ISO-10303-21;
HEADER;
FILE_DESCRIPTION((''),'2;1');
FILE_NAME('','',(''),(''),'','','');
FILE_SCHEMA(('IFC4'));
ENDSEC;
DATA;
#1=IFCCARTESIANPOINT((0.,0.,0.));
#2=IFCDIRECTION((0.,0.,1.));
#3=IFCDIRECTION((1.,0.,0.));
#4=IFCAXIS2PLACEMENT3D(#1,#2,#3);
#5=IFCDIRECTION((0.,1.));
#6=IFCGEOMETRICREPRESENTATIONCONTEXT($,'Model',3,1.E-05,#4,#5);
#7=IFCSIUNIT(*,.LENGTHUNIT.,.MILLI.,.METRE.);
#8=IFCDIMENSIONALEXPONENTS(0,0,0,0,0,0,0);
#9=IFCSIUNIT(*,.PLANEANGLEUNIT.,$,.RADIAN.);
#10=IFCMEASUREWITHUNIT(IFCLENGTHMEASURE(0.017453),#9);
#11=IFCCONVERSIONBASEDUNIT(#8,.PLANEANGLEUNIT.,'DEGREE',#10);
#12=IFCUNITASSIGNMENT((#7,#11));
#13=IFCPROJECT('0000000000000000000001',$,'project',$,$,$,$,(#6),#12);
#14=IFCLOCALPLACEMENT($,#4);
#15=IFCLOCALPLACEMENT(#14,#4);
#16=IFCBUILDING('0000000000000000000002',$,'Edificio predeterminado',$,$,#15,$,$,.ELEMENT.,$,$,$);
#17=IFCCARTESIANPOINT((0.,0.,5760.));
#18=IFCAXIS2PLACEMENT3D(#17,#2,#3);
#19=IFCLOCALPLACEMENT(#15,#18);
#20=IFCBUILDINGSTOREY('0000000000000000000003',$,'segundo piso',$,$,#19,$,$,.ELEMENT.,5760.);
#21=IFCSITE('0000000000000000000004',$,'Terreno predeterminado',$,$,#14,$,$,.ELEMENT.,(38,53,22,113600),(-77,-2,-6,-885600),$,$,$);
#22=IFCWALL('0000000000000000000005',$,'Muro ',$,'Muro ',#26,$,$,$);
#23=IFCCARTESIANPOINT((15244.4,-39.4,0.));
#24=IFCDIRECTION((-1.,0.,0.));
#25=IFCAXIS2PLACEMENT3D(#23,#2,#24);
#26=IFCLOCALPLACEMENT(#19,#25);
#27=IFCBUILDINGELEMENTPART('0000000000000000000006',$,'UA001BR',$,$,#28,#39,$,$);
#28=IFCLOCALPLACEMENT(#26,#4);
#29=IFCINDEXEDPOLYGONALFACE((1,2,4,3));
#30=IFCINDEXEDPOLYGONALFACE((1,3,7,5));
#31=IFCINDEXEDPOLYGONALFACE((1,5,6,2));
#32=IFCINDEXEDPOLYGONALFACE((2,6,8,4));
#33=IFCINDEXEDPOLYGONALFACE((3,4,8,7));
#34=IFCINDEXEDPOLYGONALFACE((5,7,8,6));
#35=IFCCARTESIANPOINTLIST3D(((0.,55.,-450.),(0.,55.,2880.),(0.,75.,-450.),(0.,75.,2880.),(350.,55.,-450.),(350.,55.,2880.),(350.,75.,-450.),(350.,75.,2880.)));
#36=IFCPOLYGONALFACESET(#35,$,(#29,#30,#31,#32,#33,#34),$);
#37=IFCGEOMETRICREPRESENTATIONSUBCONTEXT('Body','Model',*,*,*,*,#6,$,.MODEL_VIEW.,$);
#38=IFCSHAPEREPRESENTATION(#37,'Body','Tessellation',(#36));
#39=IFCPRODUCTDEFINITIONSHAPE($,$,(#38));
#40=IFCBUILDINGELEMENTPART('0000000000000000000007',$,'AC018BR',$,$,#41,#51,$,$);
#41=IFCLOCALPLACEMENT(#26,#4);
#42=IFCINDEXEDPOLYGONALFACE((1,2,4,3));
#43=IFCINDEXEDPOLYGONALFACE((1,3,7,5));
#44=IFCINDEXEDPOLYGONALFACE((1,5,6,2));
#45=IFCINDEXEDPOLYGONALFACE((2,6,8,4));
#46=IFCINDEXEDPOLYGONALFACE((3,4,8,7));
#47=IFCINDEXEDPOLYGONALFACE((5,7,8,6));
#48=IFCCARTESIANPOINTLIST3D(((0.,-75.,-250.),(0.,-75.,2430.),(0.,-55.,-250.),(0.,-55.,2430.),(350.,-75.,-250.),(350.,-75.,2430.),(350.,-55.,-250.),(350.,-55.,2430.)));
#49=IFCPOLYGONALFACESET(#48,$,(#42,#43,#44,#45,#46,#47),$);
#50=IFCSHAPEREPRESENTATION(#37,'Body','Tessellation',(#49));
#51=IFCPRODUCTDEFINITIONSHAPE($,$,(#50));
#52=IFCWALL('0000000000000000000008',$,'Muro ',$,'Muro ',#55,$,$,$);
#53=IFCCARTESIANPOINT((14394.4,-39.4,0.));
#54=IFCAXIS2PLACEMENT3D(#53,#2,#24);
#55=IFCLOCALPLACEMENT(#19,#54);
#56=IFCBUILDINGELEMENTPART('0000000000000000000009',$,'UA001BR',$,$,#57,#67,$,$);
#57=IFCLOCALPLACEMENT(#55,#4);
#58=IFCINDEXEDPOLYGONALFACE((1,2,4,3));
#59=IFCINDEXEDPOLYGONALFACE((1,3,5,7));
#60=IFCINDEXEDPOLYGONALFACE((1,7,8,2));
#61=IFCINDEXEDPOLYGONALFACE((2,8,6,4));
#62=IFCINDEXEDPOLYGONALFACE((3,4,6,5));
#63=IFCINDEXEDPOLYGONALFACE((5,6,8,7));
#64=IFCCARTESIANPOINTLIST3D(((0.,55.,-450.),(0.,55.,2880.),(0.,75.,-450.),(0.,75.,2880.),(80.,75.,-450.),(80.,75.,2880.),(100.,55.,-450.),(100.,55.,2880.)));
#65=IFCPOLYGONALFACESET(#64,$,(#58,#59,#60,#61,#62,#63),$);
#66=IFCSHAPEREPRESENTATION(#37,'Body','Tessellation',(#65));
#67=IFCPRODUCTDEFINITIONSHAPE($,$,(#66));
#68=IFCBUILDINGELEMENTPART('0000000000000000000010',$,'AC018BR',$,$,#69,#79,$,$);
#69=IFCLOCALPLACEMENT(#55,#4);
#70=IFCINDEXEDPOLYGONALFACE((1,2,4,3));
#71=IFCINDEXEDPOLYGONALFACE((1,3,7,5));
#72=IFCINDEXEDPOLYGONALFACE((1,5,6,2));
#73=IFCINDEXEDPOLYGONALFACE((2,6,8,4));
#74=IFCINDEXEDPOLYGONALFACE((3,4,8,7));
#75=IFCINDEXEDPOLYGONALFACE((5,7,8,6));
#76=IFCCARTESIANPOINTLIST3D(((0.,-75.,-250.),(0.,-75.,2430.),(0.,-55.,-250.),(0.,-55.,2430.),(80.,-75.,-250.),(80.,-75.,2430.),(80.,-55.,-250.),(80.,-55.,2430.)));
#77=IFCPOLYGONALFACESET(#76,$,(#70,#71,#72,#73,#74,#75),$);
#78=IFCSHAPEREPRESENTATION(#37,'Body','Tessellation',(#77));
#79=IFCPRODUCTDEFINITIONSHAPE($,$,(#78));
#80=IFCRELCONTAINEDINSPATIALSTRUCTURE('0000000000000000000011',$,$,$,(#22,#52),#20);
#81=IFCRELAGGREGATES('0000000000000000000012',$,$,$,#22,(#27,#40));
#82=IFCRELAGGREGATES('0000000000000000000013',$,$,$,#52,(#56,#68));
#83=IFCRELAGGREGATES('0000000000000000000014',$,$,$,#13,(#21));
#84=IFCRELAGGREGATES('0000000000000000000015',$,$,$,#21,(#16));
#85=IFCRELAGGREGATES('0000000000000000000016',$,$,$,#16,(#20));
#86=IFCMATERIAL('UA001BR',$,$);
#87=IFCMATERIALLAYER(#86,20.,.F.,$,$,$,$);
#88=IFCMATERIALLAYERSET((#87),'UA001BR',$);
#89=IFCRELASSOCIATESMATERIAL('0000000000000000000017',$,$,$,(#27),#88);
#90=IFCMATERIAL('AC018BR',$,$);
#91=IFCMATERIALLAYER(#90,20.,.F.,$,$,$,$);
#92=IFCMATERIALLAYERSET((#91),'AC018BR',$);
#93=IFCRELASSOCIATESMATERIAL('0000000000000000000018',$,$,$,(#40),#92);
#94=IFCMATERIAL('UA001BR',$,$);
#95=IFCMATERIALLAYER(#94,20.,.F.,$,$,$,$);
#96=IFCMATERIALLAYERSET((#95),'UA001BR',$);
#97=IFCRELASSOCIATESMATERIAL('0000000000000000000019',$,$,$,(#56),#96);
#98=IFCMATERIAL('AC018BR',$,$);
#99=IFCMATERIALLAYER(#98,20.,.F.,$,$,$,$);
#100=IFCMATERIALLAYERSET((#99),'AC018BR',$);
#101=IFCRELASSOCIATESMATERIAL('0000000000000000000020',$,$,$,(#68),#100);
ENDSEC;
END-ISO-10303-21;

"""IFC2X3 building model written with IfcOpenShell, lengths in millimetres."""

from ifc_helpers import new_model, entity, si_unit, converted_unit, direction, frame, origin_with_axes, place, context, subcontext, project, spatial, polyline, outline, extrude, material, layer, layer_set, layer_usage, element, aggregate, save


model = new_model("IFC2X3")

# Units and contexts
model_context = context("Model", 3, precision=1e-05, world=origin_with_axes(), true_north=direction((0.0, 1.0)))
body_context = subcontext(model_context, "Body", "Model", "MODEL_VIEW")
ifc_project = project(units=[si_unit("LENGTHUNIT", "METRE", prefix="MILLI"), converted_unit("PLANEANGLEUNIT", "DEGREE", entity("IfcLengthMeasure", 0.017453), si_unit("PLANEANGLEUNIT", "RADIAN"), dimensions=[0, 0, 0, 0, 0, 0, 0])], contexts=[model_context])

# Site, building, storey
site_placement = place(None, origin_with_axes())
site = spatial("IfcSite", under=ifc_project, at=site_placement, Name="Terreno predeterminado", CompositionType="ELEMENT", RefLatitude=(38, 53, 22, 113600), RefLongitude=(-77, -2, -6, -885600))
building_placement = place(site_placement, origin_with_axes())
building = spatial("IfcBuilding", under=site, at=building_placement, Name="Edificio predeterminado", CompositionType="ELEMENT")
storey_placement = place(building_placement, frame((0.0, 0.0, 5760.0), z_axis=(0.0, 0.0, 1.0), x_axis=(1.0, 0.0, 0.0)))
storey = spatial("IfcBuildingStorey", under=building, at=storey_placement, Name="segundo piso", CompositionType="ELEMENT", Elevation=5760.0)

# Walls, building element parts
wall_1_placement = place(storey_placement, frame((15244.4, -39.4, 0.0), z_axis=(0.0, 0.0, 1.0), x_axis=(-1.0, 0.0, 0.0)))
wall_1 = element("IfcWall", 1, at=wall_1_placement, inside=storey, Name="Muro ", ObjectType="Muro ")
ifc_material_1 = material(Name="UA001BR")
ifc_layer_1 = layer(ifc_material_1, 20.0, ventilated=False)
ifc_layer_set_1 = layer_set([ifc_layer_1], Name="UA001BR")
ifc_layer_usage_1 = layer_usage(ifc_layer_set_1, "AXIS2", "NEGATIVE", -75.0)
building_element_part_1_placement = place(wall_1_placement, origin_with_axes())
building_element_part_1 = element("IfcBuildingElementPart", 2, at=building_element_part_1_placement, material=ifc_layer_usage_1, Name="UA001BR", context=body_context, shape_type="SweptSolid", body=[
    extrude(outline(polyline([(350.0, 75.0), (350.0, 55.0), (0.0, 55.0), (0.0, 75.0), (350.0, 75.0)])), frame((0.0, 0.0, -450.0), z_axis=(0.0, 0.0, 1.0), x_axis=(1.0, 0.0, 0.0)), (0.0, 0.0, 1.0), 3330.0),
])
ifc_material_2 = material(Name="AC018BR")
ifc_layer_2 = layer(ifc_material_2, 20.0, ventilated=False)
ifc_layer_set_2 = layer_set([ifc_layer_2], Name="AC018BR")
ifc_layer_usage_2 = layer_usage(ifc_layer_set_2, "AXIS2", "NEGATIVE", 55.0)
building_element_part_2_placement = place(wall_1_placement, origin_with_axes())
building_element_part_2 = element("IfcBuildingElementPart", 3, at=building_element_part_2_placement, material=ifc_layer_usage_2, Name="AC018BR", context=body_context, shape_type="SweptSolid", body=[
    extrude(outline(polyline([(350.0, -55.0), (350.0, -75.0), (0.0, -75.0), (0.0, -55.0), (350.0, -55.0)])), frame((0.0, 0.0, -250.0), z_axis=(0.0, 0.0, 1.0), x_axis=(1.0, 0.0, 0.0)), (0.0, 0.0, 1.0), 2680.0),
])
aggregate(wall_1, [building_element_part_1, building_element_part_2])
wall_2_placement = place(storey_placement, frame((14394.4, -39.4, 0.0), z_axis=(0.0, 0.0, 1.0), x_axis=(-1.0, 0.0, 0.0)))
wall_2 = element("IfcWall", 4, at=wall_2_placement, inside=storey, Name="Muro ", ObjectType="Muro ")
ifc_material_3 = material(Name="UA001BR")
ifc_layer_3 = layer(ifc_material_3, 20.0, ventilated=False)
ifc_layer_set_3 = layer_set([ifc_layer_3], Name="UA001BR")
ifc_layer_usage_3 = layer_usage(ifc_layer_set_3, "AXIS2", "NEGATIVE", -75.0)
building_element_part_3_placement = place(wall_2_placement, origin_with_axes())
building_element_part_3 = element("IfcBuildingElementPart", 5, at=building_element_part_3_placement, material=ifc_layer_usage_3, Name="UA001BR", context=body_context, shape_type="SweptSolid", body=[
    extrude(outline(polyline([(80.0, 75.0), (100.0, 55.0), (0.0, 55.0), (0.0, 75.0), (80.0, 75.0)])), frame((0.0, 0.0, -450.0), z_axis=(0.0, 0.0, 1.0), x_axis=(1.0, 0.0, 0.0)), (0.0, 0.0, 1.0), 3330.0),
])
ifc_material_4 = material(Name="AC018BR")
ifc_layer_4 = layer(ifc_material_4, 20.0, ventilated=False)
ifc_layer_set_4 = layer_set([ifc_layer_4], Name="AC018BR")
ifc_layer_usage_4 = layer_usage(ifc_layer_set_4, "AXIS2", "NEGATIVE", 55.0)
building_element_part_4_placement = place(wall_2_placement, origin_with_axes())
building_element_part_4 = element("IfcBuildingElementPart", 6, at=building_element_part_4_placement, material=ifc_layer_usage_4, Name="AC018BR", context=body_context, shape_type="SweptSolid", body=[
    extrude(outline(polyline([(80.0, -55.0), (80.0, -75.0), (0.0, -75.0), (0.0, -55.0), (80.0, -55.0)])), frame((0.0, 0.0, -250.0), z_axis=(0.0, 0.0, 1.0), x_axis=(1.0, 0.0, 0.0)), (0.0, 0.0, 1.0), 2680.0),
])
aggregate(wall_2, [building_element_part_3, building_element_part_4])

save(model, "model.ifc")
